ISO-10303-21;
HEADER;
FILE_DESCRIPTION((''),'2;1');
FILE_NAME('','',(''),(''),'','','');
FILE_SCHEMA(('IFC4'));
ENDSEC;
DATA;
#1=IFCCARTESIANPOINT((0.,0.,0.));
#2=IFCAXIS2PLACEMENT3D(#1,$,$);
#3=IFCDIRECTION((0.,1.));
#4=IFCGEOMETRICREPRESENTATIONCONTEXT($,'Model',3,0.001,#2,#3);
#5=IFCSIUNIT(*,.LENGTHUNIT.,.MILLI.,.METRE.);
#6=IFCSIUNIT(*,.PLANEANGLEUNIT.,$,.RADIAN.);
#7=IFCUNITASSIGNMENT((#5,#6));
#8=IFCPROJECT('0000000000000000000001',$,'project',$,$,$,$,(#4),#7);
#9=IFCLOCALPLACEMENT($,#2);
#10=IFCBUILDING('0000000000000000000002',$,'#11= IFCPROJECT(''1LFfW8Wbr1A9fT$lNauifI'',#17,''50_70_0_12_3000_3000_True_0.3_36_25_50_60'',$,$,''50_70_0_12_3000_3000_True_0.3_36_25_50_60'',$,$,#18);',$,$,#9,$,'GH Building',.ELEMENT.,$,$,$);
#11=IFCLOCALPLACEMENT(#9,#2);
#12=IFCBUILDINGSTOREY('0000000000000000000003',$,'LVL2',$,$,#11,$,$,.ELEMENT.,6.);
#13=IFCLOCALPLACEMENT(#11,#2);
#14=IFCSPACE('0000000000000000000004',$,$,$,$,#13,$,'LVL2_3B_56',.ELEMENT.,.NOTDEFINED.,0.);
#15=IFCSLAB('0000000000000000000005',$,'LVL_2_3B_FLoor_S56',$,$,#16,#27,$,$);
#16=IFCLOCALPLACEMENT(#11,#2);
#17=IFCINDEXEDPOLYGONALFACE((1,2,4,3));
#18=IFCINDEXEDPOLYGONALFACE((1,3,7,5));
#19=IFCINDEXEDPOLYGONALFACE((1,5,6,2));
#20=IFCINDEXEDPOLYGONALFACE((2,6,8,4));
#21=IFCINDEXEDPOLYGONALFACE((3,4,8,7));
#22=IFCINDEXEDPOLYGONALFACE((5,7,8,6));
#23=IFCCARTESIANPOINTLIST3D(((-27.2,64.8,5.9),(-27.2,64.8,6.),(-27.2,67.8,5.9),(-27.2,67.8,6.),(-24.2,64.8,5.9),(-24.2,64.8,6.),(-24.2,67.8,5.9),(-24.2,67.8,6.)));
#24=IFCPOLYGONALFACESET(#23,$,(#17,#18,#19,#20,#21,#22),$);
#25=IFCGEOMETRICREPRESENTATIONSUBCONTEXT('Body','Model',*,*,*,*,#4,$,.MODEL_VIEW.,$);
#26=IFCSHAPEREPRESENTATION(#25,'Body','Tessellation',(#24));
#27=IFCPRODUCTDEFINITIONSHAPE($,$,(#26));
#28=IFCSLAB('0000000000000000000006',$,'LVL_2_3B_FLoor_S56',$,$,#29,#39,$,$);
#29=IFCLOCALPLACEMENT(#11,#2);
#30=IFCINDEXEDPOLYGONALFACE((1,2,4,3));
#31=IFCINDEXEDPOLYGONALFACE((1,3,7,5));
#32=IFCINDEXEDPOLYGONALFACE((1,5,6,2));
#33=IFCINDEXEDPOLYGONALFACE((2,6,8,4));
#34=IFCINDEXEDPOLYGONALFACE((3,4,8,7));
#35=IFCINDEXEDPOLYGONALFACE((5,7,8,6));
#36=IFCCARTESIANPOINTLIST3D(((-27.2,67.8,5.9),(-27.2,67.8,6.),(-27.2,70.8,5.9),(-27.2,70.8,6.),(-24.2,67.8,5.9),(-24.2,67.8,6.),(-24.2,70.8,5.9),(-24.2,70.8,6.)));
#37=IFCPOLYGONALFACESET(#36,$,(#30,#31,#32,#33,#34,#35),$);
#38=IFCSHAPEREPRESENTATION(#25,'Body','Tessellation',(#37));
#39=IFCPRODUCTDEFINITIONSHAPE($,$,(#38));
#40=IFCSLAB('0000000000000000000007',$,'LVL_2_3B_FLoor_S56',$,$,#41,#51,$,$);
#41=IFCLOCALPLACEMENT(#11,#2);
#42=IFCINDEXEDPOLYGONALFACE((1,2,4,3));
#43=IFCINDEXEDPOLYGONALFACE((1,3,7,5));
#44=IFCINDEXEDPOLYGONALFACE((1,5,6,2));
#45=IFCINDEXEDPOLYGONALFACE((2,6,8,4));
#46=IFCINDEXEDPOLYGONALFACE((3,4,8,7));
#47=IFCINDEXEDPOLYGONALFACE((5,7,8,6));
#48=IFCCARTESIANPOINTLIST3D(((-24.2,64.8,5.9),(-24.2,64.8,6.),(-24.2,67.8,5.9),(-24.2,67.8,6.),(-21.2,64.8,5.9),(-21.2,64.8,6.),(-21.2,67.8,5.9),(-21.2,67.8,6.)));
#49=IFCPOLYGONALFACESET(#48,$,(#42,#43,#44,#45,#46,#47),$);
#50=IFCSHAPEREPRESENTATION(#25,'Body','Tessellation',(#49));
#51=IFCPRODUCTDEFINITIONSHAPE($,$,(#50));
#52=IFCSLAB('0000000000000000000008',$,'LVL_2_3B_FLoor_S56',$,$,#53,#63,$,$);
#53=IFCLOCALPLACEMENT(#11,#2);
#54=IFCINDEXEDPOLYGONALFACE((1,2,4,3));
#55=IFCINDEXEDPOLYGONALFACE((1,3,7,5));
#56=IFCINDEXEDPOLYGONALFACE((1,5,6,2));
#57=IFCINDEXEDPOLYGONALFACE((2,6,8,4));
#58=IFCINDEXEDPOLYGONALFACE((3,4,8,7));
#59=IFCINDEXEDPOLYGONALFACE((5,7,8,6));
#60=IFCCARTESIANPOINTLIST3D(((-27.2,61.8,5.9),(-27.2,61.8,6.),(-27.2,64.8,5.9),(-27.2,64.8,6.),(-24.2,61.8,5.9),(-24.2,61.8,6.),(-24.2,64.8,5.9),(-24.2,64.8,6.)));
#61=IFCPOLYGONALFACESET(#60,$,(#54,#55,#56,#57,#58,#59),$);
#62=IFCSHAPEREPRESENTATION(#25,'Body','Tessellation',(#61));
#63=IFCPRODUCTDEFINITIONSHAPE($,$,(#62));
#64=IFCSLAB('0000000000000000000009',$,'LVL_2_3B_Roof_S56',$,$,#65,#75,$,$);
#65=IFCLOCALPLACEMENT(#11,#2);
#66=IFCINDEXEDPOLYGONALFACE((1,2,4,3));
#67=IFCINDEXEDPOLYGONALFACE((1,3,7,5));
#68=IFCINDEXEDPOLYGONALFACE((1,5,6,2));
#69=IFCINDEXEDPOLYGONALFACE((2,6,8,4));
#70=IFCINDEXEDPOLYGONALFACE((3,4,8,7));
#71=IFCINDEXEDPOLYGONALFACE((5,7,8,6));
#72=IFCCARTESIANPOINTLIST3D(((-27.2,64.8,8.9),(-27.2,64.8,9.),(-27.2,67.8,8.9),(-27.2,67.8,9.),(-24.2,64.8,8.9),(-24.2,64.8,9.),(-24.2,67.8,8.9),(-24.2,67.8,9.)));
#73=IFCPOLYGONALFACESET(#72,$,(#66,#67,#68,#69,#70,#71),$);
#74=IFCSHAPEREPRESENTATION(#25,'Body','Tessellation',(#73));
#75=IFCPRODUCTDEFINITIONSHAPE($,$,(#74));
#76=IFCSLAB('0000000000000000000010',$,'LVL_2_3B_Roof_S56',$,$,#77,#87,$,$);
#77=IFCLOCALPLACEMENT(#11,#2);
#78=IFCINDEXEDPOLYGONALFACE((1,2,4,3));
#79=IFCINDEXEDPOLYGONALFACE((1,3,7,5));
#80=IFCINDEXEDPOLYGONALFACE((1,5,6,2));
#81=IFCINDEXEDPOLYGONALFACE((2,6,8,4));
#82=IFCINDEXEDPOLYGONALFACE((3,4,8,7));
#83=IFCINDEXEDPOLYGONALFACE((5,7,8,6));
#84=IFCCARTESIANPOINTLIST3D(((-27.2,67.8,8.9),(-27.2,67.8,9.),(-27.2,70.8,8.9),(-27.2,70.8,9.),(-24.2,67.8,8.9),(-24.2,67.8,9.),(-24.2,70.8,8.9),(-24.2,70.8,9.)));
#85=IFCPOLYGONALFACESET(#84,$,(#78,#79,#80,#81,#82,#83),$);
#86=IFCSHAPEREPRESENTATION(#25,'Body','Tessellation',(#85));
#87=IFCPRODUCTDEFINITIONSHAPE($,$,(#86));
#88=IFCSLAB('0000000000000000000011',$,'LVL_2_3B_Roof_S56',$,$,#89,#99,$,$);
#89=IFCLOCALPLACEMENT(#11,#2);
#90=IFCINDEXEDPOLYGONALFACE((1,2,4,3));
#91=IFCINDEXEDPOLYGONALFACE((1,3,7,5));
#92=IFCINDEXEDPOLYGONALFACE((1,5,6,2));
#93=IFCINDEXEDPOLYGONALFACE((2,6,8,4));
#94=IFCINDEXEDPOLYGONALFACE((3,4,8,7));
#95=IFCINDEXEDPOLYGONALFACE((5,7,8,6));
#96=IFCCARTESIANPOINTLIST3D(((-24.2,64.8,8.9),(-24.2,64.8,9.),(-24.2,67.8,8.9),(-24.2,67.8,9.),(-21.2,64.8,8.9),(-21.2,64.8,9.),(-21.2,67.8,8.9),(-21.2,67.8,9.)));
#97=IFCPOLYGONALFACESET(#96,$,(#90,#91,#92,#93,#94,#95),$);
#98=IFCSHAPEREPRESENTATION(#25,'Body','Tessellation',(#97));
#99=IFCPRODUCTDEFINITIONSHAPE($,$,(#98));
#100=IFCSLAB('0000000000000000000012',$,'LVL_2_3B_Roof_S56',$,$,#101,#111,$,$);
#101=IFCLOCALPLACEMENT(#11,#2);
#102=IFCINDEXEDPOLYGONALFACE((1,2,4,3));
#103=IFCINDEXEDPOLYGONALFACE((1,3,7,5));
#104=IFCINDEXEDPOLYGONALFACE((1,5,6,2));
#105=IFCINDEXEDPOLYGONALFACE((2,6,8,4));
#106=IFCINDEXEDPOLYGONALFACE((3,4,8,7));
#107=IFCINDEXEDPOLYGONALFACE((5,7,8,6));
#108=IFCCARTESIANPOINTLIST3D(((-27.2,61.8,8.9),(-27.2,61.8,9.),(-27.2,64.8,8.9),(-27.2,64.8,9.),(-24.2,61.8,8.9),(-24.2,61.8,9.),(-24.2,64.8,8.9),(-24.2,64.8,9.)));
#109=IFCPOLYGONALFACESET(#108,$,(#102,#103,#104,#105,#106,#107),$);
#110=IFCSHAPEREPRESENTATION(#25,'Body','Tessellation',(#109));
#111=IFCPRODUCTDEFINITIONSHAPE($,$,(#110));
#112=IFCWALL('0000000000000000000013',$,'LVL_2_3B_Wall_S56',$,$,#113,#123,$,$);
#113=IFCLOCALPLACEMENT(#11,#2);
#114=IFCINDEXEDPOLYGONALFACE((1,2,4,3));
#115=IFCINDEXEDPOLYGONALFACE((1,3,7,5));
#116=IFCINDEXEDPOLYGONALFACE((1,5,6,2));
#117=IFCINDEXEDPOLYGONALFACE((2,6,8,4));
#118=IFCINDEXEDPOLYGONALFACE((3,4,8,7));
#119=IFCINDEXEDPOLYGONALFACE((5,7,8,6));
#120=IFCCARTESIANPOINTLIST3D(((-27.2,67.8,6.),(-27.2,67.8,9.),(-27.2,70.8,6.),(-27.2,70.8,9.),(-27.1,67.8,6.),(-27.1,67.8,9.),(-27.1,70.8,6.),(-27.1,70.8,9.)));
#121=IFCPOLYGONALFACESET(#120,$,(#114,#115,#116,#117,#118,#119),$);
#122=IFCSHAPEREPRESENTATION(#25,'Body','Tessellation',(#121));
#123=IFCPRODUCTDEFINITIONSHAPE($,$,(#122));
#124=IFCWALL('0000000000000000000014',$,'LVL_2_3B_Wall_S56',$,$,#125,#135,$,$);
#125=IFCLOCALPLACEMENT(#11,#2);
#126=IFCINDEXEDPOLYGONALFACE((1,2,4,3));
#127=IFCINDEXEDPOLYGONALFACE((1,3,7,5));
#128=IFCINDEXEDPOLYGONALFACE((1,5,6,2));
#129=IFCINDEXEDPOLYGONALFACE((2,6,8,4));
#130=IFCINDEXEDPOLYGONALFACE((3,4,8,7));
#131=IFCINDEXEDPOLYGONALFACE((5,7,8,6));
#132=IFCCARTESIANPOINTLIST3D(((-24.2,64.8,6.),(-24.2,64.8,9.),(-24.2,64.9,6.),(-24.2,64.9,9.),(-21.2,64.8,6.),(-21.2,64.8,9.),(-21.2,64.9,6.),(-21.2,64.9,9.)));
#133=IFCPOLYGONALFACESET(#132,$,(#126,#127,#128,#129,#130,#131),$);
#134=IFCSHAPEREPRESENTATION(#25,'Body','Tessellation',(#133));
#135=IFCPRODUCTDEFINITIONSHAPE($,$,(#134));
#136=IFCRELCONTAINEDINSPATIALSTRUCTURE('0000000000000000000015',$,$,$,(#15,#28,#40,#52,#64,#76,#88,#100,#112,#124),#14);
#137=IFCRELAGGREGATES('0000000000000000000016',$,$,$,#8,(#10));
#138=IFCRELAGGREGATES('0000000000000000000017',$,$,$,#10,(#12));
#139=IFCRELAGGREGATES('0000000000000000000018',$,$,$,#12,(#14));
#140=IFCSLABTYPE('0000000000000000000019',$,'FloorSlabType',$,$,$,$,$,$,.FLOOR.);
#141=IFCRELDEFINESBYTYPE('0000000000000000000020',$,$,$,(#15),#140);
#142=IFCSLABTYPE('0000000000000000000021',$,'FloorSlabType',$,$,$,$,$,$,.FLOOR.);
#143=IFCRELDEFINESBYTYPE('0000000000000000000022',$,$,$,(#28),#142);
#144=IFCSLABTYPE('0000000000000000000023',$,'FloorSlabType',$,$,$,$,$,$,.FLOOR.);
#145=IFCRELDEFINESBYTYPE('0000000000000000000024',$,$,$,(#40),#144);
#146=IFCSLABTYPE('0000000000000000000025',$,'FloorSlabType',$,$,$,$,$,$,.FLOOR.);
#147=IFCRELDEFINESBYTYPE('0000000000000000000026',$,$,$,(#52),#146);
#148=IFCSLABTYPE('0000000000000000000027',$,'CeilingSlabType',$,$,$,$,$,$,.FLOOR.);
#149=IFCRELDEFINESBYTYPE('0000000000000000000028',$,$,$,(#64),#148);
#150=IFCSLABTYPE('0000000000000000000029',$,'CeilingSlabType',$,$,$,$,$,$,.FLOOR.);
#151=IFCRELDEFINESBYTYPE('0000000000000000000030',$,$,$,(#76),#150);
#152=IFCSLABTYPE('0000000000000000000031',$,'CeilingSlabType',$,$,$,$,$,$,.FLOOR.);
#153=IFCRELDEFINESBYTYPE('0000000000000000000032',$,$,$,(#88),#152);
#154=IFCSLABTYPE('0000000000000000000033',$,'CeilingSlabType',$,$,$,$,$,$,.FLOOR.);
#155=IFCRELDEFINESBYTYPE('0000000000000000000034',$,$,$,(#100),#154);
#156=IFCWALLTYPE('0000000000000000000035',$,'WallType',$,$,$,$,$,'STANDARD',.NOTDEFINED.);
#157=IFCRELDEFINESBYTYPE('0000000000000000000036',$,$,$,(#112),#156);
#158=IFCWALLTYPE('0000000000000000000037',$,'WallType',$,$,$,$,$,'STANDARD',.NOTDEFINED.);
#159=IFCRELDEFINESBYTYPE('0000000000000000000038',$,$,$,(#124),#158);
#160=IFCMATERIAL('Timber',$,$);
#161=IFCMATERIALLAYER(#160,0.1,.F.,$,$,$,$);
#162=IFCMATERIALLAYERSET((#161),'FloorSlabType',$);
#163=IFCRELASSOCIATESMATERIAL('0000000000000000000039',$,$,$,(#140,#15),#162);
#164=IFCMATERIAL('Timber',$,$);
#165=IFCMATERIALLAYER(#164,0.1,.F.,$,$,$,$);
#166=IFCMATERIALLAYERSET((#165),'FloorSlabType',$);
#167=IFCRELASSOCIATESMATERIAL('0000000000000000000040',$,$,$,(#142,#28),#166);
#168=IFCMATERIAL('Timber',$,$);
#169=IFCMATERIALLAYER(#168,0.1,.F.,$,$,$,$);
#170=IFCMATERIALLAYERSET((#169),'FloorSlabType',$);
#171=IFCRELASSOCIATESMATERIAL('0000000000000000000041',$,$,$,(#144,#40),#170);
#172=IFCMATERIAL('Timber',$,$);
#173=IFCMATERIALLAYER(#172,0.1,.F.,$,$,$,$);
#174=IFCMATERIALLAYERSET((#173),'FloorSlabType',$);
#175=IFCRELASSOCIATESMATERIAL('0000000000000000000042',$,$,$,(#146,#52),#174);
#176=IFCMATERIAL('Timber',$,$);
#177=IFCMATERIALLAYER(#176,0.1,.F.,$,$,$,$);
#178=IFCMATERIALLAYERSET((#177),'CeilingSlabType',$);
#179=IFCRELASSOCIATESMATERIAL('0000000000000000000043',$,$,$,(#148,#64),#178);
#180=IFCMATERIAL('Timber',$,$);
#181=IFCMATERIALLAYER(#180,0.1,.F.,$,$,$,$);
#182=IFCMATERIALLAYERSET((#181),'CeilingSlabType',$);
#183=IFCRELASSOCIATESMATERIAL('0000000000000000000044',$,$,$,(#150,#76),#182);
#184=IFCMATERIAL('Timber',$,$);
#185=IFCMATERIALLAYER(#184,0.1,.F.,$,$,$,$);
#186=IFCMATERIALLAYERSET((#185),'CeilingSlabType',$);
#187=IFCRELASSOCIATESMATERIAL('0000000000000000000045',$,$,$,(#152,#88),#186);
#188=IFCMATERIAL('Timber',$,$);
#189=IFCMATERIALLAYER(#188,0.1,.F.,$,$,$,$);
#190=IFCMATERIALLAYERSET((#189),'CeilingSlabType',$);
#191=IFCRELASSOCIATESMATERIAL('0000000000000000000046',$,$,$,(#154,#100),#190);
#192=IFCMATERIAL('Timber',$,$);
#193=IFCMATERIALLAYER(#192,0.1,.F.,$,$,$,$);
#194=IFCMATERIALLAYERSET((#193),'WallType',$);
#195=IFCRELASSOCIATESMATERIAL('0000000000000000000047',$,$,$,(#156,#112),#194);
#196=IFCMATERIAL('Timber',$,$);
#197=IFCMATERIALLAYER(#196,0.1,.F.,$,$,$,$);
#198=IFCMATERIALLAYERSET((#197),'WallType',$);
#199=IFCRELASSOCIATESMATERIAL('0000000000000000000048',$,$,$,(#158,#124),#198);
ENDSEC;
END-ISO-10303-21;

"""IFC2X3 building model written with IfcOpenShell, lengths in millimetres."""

from ifc_helpers import new_model, si_unit, direction, frame, frame_2d, origin, place, context, subcontext, project, spatial, rectangle, extrude, material, layer, layer_set, layer_usage, type_object, element, save


model = new_model("IFC2X3")

# Units and contexts
model_context = context("Model", 3, precision=0.001, world=origin(), true_north=direction((0.0, 1.0)))
body_context = subcontext(model_context, "Body", "Model", "MODEL_VIEW")
ifc_project = project(units=[si_unit("LENGTHUNIT", "METRE", prefix="MILLI"), si_unit("PLANEANGLEUNIT", "RADIAN")], contexts=[model_context])

# Building, storey
building_placement = place(None, origin())
building = spatial("IfcBuilding", under=ifc_project, at=building_placement, Name="#11= IFCPROJECT('1LFfW8Wbr1A9fT$lNauifI',#17,'50_70_0_12_3000_3000_True_0.3_36_25_50_60',$,$,'50_70_0_12_3000_3000_True_0.3_36_25_50_60',$,$,#18);", LongName="GH Building", CompositionType="ELEMENT")
storey_placement = place(building_placement, origin())
storey = spatial("IfcBuildingStorey", under=building, at=storey_placement, Name="LVL2", CompositionType="ELEMENT", Elevation=6.0)

# Shared definitions
space_1_placement = place(storey_placement, origin())
space_1 = spatial("IfcSpace", under=storey, at=space_1_placement, LongName="LVL2_3B_56", CompositionType="ELEMENT", InteriorOrExteriorSpace="NOTDEFINED", ElevationWithFlooring=0.0)

# Slabs
ifc_material_1 = material(Name="Timber")
ifc_layer_1 = layer(ifc_material_1, 0.1, ventilated=False)
ifc_layer_set_1 = layer_set([ifc_layer_1], Name="FloorSlabType")
ifc_layer_usage_1 = layer_usage(ifc_layer_set_1, "AXIS3", "NEGATIVE", -0.1)
slab_type_1 = type_object("IfcSlabType", Name="FloorSlabType", PredefinedType="FLOOR", material=ifc_layer_set_1)
slab_1_placement = place(space_1_placement, frame((-24.2, 64.8, 5.9), z_axis=(0.0, 0.0, 1.0), x_axis=(0.0, 1.0, 0.0)))
element("IfcSlab", 1, at=slab_1_placement, inside=space_1, type_object=slab_type_1, material=ifc_layer_usage_1, Name="LVL_2_3B_FLoor_S56", context=body_context, shape_type="SweptSolid", body=[
    extrude(rectangle(XDim=3.0, YDim=3.0, at=frame_2d((1.5, 1.5))), origin(), (0.0, 0.0, 1.0), 0.1),
])
ifc_material_2 = material(Name="Timber")
ifc_layer_2 = layer(ifc_material_2, 0.1, ventilated=False)
ifc_layer_set_2 = layer_set([ifc_layer_2], Name="FloorSlabType")
ifc_layer_usage_2 = layer_usage(ifc_layer_set_2, "AXIS3", "NEGATIVE", -0.1)
slab_type_2 = type_object("IfcSlabType", Name="FloorSlabType", PredefinedType="FLOOR", material=ifc_layer_set_2)
slab_2_placement = place(space_1_placement, frame((-24.2, 67.8, 5.9), z_axis=(0.0, 0.0, 1.0), x_axis=(0.0, 1.0, 0.0)))
element("IfcSlab", 2, at=slab_2_placement, inside=space_1, type_object=slab_type_2, material=ifc_layer_usage_2, Name="LVL_2_3B_FLoor_S56", context=body_context, shape_type="SweptSolid", body=[
    extrude(rectangle(XDim=3.0, YDim=3.0, at=frame_2d((1.5, 1.5))), origin(), (0.0, 0.0, 1.0), 0.1),
])
ifc_material_3 = material(Name="Timber")
ifc_layer_3 = layer(ifc_material_3, 0.1, ventilated=False)
ifc_layer_set_3 = layer_set([ifc_layer_3], Name="FloorSlabType")
ifc_layer_usage_3 = layer_usage(ifc_layer_set_3, "AXIS3", "NEGATIVE", -0.1)
slab_type_3 = type_object("IfcSlabType", Name="FloorSlabType", PredefinedType="FLOOR", material=ifc_layer_set_3)
slab_3_placement = place(space_1_placement, frame((-21.2, 64.8, 5.9), z_axis=(0.0, 0.0, 1.0), x_axis=(0.0, 1.0, 0.0)))
element("IfcSlab", 3, at=slab_3_placement, inside=space_1, type_object=slab_type_3, material=ifc_layer_usage_3, Name="LVL_2_3B_FLoor_S56", context=body_context, shape_type="SweptSolid", body=[
    extrude(rectangle(XDim=3.0, YDim=3.0, at=frame_2d((1.5, 1.5))), origin(), (0.0, 0.0, 1.0), 0.1),
])
ifc_material_4 = material(Name="Timber")
ifc_layer_4 = layer(ifc_material_4, 0.1, ventilated=False)
ifc_layer_set_4 = layer_set([ifc_layer_4], Name="FloorSlabType")
ifc_layer_usage_4 = layer_usage(ifc_layer_set_4, "AXIS3", "NEGATIVE", -0.1)
slab_type_4 = type_object("IfcSlabType", Name="FloorSlabType", PredefinedType="FLOOR", material=ifc_layer_set_4)
slab_4_placement = place(space_1_placement, frame((-24.2, 61.8, 5.9), z_axis=(0.0, 0.0, 1.0), x_axis=(0.0, 1.0, 0.0)))
element("IfcSlab", 4, at=slab_4_placement, inside=space_1, type_object=slab_type_4, material=ifc_layer_usage_4, Name="LVL_2_3B_FLoor_S56", context=body_context, shape_type="SweptSolid", body=[
    extrude(rectangle(XDim=3.0, YDim=3.0, at=frame_2d((1.5, 1.5))), origin(), (0.0, 0.0, 1.0), 0.1),
])
ifc_material_5 = material(Name="Timber")
ifc_layer_5 = layer(ifc_material_5, 0.1, ventilated=False)
ifc_layer_set_5 = layer_set([ifc_layer_5], Name="CeilingSlabType")
ifc_layer_usage_5 = layer_usage(ifc_layer_set_5, "AXIS3", "NEGATIVE", -0.1)
slab_type_5 = type_object("IfcSlabType", Name="CeilingSlabType", PredefinedType="FLOOR", material=ifc_layer_set_5)
slab_5_placement = place(space_1_placement, frame((-24.2, 64.8, 8.9), z_axis=(0.0, 0.0, 1.0), x_axis=(0.0, 1.0, 0.0)))
element("IfcSlab", 5, at=slab_5_placement, inside=space_1, type_object=slab_type_5, material=ifc_layer_usage_5, Name="LVL_2_3B_Roof_S56", context=body_context, shape_type="SweptSolid", body=[
    extrude(rectangle(XDim=3.0, YDim=3.0, at=frame_2d((1.5, 1.5))), origin(), (0.0, 0.0, 1.0), 0.1),
])
ifc_material_6 = material(Name="Timber")
ifc_layer_6 = layer(ifc_material_6, 0.1, ventilated=False)
ifc_layer_set_6 = layer_set([ifc_layer_6], Name="CeilingSlabType")
ifc_layer_usage_6 = layer_usage(ifc_layer_set_6, "AXIS3", "NEGATIVE", -0.1)
slab_type_6 = type_object("IfcSlabType", Name="CeilingSlabType", PredefinedType="FLOOR", material=ifc_layer_set_6)
slab_6_placement = place(space_1_placement, frame((-24.2, 67.8, 8.9), z_axis=(0.0, 0.0, 1.0), x_axis=(0.0, 1.0, 0.0)))
element("IfcSlab", 6, at=slab_6_placement, inside=space_1, type_object=slab_type_6, material=ifc_layer_usage_6, Name="LVL_2_3B_Roof_S56", context=body_context, shape_type="SweptSolid", body=[
    extrude(rectangle(XDim=3.0, YDim=3.0, at=frame_2d((1.5, 1.5))), origin(), (0.0, 0.0, 1.0), 0.1),
])
ifc_material_7 = material(Name="Timber")
ifc_layer_7 = layer(ifc_material_7, 0.1, ventilated=False)
ifc_layer_set_7 = layer_set([ifc_layer_7], Name="CeilingSlabType")
ifc_layer_usage_7 = layer_usage(ifc_layer_set_7, "AXIS3", "NEGATIVE", -0.1)
slab_type_7 = type_object("IfcSlabType", Name="CeilingSlabType", PredefinedType="FLOOR", material=ifc_layer_set_7)
slab_7_placement = place(space_1_placement, frame((-21.2, 64.8, 8.9), z_axis=(0.0, 0.0, 1.0), x_axis=(0.0, 1.0, 0.0)))
element("IfcSlab", 7, at=slab_7_placement, inside=space_1, type_object=slab_type_7, material=ifc_layer_usage_7, Name="LVL_2_3B_Roof_S56", context=body_context, shape_type="SweptSolid", body=[
    extrude(rectangle(XDim=3.0, YDim=3.0, at=frame_2d((1.5, 1.5))), origin(), (0.0, 0.0, 1.0), 0.1),
])
ifc_material_8 = material(Name="Timber")
ifc_layer_8 = layer(ifc_material_8, 0.1, ventilated=False)
ifc_layer_set_8 = layer_set([ifc_layer_8], Name="CeilingSlabType")
ifc_layer_usage_8 = layer_usage(ifc_layer_set_8, "AXIS3", "NEGATIVE", -0.1)
slab_type_8 = type_object("IfcSlabType", Name="CeilingSlabType", PredefinedType="FLOOR", material=ifc_layer_set_8)
slab_8_placement = place(space_1_placement, frame((-24.2, 61.8, 8.9), z_axis=(0.0, 0.0, 1.0), x_axis=(0.0, 1.0, 0.0)))
element("IfcSlab", 8, at=slab_8_placement, inside=space_1, type_object=slab_type_8, material=ifc_layer_usage_8, Name="LVL_2_3B_Roof_S56", context=body_context, shape_type="SweptSolid", body=[
    extrude(rectangle(XDim=3.0, YDim=3.0, at=frame_2d((1.5, 1.5))), origin(), (0.0, 0.0, 1.0), 0.1),
])

# Walls
ifc_material_9 = material(Name="Timber")
ifc_layer_9 = layer(ifc_material_9, 0.1, ventilated=False)
ifc_layer_set_9 = layer_set([ifc_layer_9], Name="WallType")
ifc_layer_usage_9 = layer_usage(ifc_layer_set_9, "AXIS2", "NEGATIVE", 0.0)
wall_type_1 = type_object("IfcWallType", Name="WallType", ElementType="STANDARD", PredefinedType="NOTDEFINED", material=ifc_layer_set_9)
wall_1_placement = place(space_1_placement, frame((-27.2, 67.8, 6.0), z_axis=(0.0, 0.0, 1.0), x_axis=(0.0, 1.0, 0.0)))
element("IfcWall", 9, at=wall_1_placement, inside=space_1, type_object=wall_type_1, material=ifc_layer_usage_9, Name="LVL_2_3B_Wall_S56", context=body_context, shape_type="SweptSolid", body=[
    extrude(rectangle(XDim=3.0, YDim=0.1, at=frame_2d((1.5, -0.1))), origin(), (0.0, 0.0, 1.0), 3.0),
])
ifc_material_10 = material(Name="Timber")
ifc_layer_10 = layer(ifc_material_10, 0.1, ventilated=False)
ifc_layer_set_10 = layer_set([ifc_layer_10], Name="WallType")
ifc_layer_usage_10 = layer_usage(ifc_layer_set_10, "AXIS2", "NEGATIVE", 0.0)
wall_type_2 = type_object("IfcWallType", Name="WallType", ElementType="STANDARD", PredefinedType="NOTDEFINED", material=ifc_layer_set_10)
wall_2_placement = place(space_1_placement, frame((-21.2, 64.8, 6.0), z_axis=(0.0, 0.0, 1.0), x_axis=(-1.0, 0.0, 0.0)))
element("IfcWall", 10, at=wall_2_placement, inside=space_1, type_object=wall_type_2, material=ifc_layer_usage_10, Name="LVL_2_3B_Wall_S56", context=body_context, shape_type="SweptSolid", body=[
    extrude(rectangle(XDim=3.0, YDim=0.1, at=frame_2d((1.5, -0.1))), origin(), (0.0, 0.0, 1.0), 3.0),
])

save(model, "model.ifc")
